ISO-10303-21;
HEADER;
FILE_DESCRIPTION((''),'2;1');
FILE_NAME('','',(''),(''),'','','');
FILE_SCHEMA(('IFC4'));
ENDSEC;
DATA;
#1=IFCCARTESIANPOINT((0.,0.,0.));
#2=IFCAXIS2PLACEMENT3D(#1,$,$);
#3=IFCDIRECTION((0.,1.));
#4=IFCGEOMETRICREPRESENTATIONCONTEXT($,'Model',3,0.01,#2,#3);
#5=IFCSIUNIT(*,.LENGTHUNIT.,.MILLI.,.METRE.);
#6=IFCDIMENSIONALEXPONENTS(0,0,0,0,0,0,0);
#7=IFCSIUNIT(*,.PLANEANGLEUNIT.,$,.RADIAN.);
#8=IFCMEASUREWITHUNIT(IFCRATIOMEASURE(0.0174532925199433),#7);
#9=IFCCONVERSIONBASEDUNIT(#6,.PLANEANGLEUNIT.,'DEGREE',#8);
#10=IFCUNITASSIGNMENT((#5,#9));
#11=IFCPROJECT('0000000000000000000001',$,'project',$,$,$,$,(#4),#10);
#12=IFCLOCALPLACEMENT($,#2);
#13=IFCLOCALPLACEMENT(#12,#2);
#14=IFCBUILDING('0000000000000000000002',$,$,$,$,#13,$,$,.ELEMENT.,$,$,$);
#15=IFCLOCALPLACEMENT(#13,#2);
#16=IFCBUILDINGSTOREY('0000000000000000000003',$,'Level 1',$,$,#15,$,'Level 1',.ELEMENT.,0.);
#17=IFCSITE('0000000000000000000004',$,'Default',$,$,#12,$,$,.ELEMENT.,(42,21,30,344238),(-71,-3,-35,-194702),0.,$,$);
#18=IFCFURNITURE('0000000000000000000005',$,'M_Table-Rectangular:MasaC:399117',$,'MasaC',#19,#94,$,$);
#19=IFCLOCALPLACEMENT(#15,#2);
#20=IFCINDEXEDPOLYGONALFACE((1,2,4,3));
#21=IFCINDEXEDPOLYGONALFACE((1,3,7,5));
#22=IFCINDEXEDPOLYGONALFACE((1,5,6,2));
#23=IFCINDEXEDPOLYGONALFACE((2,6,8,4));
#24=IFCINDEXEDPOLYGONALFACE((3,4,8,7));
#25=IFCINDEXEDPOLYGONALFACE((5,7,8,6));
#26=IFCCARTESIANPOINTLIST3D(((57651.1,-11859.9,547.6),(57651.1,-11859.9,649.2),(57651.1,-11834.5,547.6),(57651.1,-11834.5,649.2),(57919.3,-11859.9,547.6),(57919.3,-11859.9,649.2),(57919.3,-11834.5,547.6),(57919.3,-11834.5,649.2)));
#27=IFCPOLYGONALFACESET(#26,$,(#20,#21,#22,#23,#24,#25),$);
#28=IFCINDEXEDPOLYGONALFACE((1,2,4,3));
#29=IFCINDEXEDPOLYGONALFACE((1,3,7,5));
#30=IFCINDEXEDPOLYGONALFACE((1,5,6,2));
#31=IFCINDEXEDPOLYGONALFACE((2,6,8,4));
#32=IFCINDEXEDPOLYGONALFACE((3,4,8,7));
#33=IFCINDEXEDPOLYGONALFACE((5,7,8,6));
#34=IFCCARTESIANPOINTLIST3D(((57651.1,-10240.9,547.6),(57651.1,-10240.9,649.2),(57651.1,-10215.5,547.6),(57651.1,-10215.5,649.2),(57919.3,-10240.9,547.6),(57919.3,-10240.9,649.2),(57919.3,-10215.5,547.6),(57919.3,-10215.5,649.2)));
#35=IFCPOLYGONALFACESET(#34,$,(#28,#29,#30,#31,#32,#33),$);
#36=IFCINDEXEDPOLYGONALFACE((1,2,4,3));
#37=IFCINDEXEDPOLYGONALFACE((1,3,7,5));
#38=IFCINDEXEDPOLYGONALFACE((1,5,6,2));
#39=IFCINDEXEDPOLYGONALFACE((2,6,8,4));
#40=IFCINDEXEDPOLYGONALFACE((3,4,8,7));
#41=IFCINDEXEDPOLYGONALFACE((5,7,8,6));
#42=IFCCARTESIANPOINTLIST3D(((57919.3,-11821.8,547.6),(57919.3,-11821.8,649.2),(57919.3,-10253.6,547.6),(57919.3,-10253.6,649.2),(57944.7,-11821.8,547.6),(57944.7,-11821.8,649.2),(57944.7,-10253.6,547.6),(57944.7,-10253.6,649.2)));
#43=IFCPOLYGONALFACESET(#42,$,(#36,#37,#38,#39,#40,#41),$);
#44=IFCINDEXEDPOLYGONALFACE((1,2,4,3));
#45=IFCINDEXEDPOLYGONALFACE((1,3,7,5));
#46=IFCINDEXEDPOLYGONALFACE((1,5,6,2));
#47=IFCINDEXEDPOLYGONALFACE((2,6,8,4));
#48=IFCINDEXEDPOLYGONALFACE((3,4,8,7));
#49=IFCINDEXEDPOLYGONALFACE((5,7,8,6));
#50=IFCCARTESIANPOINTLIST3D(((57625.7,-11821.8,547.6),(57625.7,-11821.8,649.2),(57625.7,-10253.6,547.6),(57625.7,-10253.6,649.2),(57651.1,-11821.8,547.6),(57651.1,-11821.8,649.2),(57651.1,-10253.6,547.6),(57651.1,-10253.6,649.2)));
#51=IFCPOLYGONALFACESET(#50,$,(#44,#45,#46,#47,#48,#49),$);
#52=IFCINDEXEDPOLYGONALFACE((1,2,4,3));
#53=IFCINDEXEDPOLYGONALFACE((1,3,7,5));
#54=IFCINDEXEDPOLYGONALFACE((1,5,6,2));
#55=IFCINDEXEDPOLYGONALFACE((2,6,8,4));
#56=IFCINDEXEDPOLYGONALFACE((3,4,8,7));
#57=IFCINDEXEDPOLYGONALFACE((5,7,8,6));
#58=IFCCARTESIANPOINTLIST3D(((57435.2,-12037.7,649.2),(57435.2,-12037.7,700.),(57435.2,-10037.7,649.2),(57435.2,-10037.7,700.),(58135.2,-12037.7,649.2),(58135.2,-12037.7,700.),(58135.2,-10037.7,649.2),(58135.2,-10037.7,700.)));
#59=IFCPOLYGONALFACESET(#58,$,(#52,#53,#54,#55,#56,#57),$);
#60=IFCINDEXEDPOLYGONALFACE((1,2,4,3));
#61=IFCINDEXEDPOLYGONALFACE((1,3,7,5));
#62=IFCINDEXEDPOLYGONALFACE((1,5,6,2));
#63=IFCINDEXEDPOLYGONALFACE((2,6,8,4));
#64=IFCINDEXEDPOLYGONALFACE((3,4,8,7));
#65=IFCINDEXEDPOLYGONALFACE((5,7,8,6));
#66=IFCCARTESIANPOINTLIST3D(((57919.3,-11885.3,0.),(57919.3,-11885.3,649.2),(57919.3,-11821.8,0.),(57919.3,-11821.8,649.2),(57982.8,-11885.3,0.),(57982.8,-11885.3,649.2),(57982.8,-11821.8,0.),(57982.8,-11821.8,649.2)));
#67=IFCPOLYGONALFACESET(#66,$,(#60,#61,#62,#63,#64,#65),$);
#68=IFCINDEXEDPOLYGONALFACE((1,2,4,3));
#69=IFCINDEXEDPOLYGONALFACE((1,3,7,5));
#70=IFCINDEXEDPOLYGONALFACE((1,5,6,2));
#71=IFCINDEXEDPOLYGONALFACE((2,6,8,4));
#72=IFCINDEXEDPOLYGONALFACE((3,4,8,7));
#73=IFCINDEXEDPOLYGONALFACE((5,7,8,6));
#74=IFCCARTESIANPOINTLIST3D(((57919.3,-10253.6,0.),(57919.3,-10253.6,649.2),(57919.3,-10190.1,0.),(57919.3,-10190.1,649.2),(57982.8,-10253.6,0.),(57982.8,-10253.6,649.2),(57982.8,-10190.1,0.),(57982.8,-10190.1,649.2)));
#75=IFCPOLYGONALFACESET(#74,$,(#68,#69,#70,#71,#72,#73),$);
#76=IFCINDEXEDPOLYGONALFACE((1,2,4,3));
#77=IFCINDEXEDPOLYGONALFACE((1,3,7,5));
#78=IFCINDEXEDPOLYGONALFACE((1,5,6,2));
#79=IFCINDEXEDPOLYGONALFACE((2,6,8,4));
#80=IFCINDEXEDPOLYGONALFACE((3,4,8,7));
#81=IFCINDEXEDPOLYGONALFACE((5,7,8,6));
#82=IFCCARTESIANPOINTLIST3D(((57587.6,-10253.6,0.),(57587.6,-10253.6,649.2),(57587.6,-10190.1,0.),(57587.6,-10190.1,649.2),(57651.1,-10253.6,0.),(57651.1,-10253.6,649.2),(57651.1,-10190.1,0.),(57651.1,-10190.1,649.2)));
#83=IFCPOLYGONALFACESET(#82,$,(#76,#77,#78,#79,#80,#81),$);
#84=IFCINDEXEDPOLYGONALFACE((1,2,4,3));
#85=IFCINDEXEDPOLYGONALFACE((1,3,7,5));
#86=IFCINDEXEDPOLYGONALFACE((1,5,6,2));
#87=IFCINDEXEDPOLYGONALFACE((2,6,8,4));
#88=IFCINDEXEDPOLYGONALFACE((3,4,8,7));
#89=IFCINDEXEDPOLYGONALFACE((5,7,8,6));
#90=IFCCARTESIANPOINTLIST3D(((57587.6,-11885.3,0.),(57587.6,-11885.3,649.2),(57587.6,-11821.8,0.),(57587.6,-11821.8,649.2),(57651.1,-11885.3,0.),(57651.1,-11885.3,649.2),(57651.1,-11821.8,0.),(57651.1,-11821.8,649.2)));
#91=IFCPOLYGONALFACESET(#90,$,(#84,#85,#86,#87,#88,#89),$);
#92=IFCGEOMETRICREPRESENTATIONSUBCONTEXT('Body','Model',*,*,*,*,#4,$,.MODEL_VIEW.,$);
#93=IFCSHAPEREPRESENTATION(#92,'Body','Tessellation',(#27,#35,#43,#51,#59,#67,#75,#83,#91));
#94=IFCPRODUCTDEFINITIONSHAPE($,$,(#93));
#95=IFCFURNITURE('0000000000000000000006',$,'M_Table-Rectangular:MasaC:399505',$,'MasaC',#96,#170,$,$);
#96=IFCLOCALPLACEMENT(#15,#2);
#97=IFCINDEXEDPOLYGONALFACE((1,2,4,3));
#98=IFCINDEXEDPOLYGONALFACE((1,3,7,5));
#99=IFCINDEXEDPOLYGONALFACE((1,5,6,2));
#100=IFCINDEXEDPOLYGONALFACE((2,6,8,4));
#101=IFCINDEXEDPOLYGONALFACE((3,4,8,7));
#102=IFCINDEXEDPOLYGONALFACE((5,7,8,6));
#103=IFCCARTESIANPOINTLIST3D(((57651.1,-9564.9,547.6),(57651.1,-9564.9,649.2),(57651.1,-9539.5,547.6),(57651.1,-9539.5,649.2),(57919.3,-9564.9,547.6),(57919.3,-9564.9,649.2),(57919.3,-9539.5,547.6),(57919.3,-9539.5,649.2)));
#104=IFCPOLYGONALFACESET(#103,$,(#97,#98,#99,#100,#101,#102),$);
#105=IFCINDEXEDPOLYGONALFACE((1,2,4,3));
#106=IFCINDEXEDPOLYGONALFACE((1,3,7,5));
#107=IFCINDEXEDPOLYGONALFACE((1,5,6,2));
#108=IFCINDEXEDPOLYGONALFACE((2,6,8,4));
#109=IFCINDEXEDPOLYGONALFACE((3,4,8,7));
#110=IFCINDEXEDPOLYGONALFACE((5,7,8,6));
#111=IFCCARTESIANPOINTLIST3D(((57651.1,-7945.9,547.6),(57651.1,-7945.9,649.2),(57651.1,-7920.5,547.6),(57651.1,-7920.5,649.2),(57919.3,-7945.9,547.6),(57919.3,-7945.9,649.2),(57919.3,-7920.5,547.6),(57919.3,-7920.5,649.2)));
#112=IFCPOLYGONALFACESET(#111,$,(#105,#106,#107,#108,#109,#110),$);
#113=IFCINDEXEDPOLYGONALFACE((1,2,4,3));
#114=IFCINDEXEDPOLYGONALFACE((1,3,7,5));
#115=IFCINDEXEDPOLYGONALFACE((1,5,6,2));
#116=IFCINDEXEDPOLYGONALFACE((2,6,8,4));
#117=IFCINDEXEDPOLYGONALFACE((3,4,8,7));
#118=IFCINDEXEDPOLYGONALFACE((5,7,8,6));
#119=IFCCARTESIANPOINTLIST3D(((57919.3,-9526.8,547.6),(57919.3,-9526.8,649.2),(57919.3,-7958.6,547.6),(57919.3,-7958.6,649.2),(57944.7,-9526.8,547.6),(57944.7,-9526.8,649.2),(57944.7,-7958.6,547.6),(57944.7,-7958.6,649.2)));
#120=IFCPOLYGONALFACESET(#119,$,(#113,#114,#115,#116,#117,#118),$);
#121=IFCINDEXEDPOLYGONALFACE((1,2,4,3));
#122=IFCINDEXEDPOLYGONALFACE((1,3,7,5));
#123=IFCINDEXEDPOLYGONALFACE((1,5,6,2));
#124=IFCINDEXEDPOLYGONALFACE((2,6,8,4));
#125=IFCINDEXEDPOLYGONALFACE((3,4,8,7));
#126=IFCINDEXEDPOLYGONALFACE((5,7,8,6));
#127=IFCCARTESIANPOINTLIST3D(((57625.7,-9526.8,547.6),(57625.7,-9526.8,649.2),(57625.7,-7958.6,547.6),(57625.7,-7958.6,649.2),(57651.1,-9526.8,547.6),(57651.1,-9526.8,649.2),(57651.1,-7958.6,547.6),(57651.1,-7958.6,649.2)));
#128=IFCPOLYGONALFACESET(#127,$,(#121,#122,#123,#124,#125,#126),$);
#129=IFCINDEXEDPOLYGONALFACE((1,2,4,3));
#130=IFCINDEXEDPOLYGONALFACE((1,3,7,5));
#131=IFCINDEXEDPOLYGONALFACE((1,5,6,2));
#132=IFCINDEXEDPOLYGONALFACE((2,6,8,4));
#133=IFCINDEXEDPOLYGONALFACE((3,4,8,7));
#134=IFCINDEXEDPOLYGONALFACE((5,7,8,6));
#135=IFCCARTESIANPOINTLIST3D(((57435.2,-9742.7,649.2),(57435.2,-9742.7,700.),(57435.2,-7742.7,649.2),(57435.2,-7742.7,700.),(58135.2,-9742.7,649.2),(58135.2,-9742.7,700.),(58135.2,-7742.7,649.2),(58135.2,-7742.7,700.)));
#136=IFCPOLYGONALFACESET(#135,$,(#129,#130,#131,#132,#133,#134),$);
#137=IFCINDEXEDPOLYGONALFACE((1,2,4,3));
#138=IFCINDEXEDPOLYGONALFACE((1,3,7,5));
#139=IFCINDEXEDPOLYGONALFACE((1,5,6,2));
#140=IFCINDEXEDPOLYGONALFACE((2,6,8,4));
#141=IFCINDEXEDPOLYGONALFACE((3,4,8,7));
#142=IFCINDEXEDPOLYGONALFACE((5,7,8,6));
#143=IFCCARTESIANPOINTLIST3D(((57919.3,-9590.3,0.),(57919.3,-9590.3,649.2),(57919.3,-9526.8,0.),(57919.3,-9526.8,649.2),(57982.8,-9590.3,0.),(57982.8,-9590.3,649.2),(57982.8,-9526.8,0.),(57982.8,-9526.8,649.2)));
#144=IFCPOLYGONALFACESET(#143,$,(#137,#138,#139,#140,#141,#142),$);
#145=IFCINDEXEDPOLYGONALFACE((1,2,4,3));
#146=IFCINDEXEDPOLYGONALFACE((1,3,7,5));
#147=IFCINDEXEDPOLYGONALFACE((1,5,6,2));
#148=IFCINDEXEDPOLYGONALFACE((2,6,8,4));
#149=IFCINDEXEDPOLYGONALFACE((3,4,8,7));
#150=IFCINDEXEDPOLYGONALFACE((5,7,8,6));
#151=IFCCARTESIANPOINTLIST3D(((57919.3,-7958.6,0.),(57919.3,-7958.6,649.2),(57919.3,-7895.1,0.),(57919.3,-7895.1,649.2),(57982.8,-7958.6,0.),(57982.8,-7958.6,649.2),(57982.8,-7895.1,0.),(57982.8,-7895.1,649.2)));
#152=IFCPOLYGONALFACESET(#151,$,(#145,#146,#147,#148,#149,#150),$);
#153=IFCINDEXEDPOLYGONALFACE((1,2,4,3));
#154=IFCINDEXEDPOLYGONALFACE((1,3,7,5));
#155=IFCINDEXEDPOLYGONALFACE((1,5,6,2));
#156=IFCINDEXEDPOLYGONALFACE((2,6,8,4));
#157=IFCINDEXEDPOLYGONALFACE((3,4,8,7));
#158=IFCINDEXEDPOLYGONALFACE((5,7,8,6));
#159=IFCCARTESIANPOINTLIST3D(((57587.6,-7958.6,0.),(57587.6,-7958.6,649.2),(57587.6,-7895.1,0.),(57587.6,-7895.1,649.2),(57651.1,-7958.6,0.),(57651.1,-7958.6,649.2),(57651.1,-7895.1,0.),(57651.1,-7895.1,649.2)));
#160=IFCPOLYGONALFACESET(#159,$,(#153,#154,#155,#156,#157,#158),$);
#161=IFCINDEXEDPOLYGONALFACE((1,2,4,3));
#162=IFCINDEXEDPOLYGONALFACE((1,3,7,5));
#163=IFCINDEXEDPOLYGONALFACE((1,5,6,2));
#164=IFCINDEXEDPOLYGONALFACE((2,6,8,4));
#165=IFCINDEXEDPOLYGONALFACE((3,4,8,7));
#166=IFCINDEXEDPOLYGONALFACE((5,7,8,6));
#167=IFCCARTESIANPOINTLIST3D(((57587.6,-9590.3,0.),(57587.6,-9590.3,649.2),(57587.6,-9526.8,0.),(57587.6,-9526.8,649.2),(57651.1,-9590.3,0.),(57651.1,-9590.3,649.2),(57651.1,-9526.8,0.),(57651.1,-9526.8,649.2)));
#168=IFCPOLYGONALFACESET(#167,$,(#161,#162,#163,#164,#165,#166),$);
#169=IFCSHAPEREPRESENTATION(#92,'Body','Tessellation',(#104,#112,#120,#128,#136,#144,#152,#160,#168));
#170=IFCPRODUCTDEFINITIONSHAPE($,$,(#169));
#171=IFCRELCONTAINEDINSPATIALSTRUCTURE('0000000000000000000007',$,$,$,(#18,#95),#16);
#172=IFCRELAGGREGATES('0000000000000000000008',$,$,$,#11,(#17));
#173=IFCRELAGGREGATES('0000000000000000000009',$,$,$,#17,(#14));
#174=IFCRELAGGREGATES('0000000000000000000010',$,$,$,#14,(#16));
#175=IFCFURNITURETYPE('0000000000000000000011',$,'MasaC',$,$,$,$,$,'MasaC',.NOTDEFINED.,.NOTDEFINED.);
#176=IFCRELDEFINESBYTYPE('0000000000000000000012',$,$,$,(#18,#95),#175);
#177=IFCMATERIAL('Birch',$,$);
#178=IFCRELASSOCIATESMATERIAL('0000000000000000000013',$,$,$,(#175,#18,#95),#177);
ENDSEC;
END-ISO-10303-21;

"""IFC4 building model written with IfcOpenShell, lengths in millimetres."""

from ifc_helpers import new_model, entity, si_unit, converted_unit, direction, frame, frame_2d, origin, origin_2d_with_axis, place, context, subcontext, project, spatial, rectangle, extrude, source, transform, mapped, material, type_object, type_shapes, element, save


model = new_model("IFC4")

# Units and contexts
model_context = context("Model", 3, precision=0.01, world=origin(), true_north=direction((0.0, 1.0)))
body_context = subcontext(model_context, "Body", "Model", "MODEL_VIEW")
ifc_project = project(units=[si_unit("LENGTHUNIT", "METRE", prefix="MILLI"), converted_unit("PLANEANGLEUNIT", "DEGREE", entity("IfcRatioMeasure", 0.0174532925199433), si_unit("PLANEANGLEUNIT", "RADIAN"), dimensions=[0, 0, 0, 0, 0, 0, 0])], contexts=[model_context])

# Site, building, storey
site_placement = place(None, origin())
site = spatial("IfcSite", under=ifc_project, at=site_placement, Name="Default", CompositionType="ELEMENT", RefLatitude=(42, 21, 30, 344238), RefLongitude=(-71, -3, -35, -194702), RefElevation=0.0)
building_placement = place(site_placement, origin())
building = spatial("IfcBuilding", under=site, at=building_placement, CompositionType="ELEMENT")
storey_placement = place(building_placement, origin())
storey = spatial("IfcBuildingStorey", under=building, at=storey_placement, Name="Level 1", LongName="Level 1", CompositionType="ELEMENT", Elevation=0.0)

# Furniture
ifc_material_1 = material(Name="Birch")
furniture_type_1 = type_object("IfcFurnitureType", Name="MasaC", ElementType="MasaC", AssemblyPlace="NOTDEFINED", PredefinedType="NOTDEFINED", material=ifc_material_1)
shared_shape_1 = source(origin(), body_context, "Body", "SweptSolid", [
    extrude(rectangle(XDim=25.4, YDim=268.2, at=origin_2d_with_axis()), frame((809.5, 0.0, 547.6)), (0.0, 0.0, 1.0), 101.6),
    extrude(rectangle(XDim=268.2, YDim=25.4, at=origin_2d_with_axis()), frame((-809.5, 0.0, 547.6), z_axis=(0.0, 0.0, 1.0), x_axis=(0.0, 1.0, 0.0)), (0.0, 0.0, 1.0), 101.6),
    extrude(rectangle(XDim=1568.2, YDim=25.4, at=origin_2d_with_axis()), frame((0.0, 146.8, 547.6), z_axis=(0.0, 0.0, 1.0), x_axis=(-1.0, 0.0, 0.0)), (0.0, 0.0, 1.0), 101.6),
    extrude(rectangle(XDim=25.4, YDim=1568.2, at=origin_2d_with_axis()), frame((0.0, -146.8, 547.6), z_axis=(0.0, 0.0, 1.0), x_axis=(0.0, 1.0, 0.0)), (0.0, 0.0, 1.0), 101.6),
    extrude(rectangle(XDim=2000.0, YDim=700.0, at=origin_2d_with_axis()), frame((0.0, 0.0, 649.2), z_axis=(0.0, 0.0, 1.0), x_axis=(-1.0, 0.0, 0.0)), (0.0, 0.0, 1.0), 50.8),
    extrude(rectangle(XDim=63.5, YDim=63.5, at=origin_2d_with_axis()), frame((815.9, 165.9, 0.0), z_axis=(0.0, 0.0, 1.0), x_axis=(0.0, -1.0, 0.0)), (0.0, 0.0, 1.0), 649.2),
    extrude(rectangle(XDim=63.5, YDim=63.5, at=frame_2d((0.0, 0.0), x_axis=(1.0, 0.0))), frame((-815.8, 165.9, 0.0), z_axis=(0.0, 0.0, 1.0), x_axis=(-1.0, 0.0, 0.0)), (0.0, 0.0, 1.0), 649.2),
    extrude(rectangle(XDim=63.5, YDim=63.5, at=origin_2d_with_axis()), frame((-815.9, -165.9, 0.0), z_axis=(0.0, 0.0, 1.0), x_axis=(0.0, 1.0, 0.0)), (0.0, 0.0, 1.0), 649.2),
    extrude(rectangle(XDim=63.5, YDim=63.5, at=origin_2d_with_axis()), frame((815.9, -165.9, 0.0)), (0.0, 0.0, 1.0), 649.2),
])
type_shapes(furniture_type_1, [shared_shape_1])
for number, where, z_axis, x_axis, name in (
    (1, (57785.2, -11037.7, 0.0), (0.0, 0.0, 1.0), (0.0, -1.0, 0.0), "M_Table-Rectangular:MasaC:399117"),
    (2, (57785.2, -8742.7, 0.0), (0.0, 0.0, 1.0), (0.0, -1.0, 0.0), "M_Table-Rectangular:MasaC:399505"),
):
    element("IfcFurniture", number, at=place(storey_placement, frame(where, z_axis=z_axis, x_axis=x_axis)), inside=storey, type_object=furniture_type_1, material=ifc_material_1, Name=name, ObjectType="MasaC", context=body_context, shape_type="MappedRepresentation", body=[
        mapped(shared_shape_1, transform((0.0, 0.0, 0.0), scale=1.0)),
    ])

save(model, "model.ifc")
